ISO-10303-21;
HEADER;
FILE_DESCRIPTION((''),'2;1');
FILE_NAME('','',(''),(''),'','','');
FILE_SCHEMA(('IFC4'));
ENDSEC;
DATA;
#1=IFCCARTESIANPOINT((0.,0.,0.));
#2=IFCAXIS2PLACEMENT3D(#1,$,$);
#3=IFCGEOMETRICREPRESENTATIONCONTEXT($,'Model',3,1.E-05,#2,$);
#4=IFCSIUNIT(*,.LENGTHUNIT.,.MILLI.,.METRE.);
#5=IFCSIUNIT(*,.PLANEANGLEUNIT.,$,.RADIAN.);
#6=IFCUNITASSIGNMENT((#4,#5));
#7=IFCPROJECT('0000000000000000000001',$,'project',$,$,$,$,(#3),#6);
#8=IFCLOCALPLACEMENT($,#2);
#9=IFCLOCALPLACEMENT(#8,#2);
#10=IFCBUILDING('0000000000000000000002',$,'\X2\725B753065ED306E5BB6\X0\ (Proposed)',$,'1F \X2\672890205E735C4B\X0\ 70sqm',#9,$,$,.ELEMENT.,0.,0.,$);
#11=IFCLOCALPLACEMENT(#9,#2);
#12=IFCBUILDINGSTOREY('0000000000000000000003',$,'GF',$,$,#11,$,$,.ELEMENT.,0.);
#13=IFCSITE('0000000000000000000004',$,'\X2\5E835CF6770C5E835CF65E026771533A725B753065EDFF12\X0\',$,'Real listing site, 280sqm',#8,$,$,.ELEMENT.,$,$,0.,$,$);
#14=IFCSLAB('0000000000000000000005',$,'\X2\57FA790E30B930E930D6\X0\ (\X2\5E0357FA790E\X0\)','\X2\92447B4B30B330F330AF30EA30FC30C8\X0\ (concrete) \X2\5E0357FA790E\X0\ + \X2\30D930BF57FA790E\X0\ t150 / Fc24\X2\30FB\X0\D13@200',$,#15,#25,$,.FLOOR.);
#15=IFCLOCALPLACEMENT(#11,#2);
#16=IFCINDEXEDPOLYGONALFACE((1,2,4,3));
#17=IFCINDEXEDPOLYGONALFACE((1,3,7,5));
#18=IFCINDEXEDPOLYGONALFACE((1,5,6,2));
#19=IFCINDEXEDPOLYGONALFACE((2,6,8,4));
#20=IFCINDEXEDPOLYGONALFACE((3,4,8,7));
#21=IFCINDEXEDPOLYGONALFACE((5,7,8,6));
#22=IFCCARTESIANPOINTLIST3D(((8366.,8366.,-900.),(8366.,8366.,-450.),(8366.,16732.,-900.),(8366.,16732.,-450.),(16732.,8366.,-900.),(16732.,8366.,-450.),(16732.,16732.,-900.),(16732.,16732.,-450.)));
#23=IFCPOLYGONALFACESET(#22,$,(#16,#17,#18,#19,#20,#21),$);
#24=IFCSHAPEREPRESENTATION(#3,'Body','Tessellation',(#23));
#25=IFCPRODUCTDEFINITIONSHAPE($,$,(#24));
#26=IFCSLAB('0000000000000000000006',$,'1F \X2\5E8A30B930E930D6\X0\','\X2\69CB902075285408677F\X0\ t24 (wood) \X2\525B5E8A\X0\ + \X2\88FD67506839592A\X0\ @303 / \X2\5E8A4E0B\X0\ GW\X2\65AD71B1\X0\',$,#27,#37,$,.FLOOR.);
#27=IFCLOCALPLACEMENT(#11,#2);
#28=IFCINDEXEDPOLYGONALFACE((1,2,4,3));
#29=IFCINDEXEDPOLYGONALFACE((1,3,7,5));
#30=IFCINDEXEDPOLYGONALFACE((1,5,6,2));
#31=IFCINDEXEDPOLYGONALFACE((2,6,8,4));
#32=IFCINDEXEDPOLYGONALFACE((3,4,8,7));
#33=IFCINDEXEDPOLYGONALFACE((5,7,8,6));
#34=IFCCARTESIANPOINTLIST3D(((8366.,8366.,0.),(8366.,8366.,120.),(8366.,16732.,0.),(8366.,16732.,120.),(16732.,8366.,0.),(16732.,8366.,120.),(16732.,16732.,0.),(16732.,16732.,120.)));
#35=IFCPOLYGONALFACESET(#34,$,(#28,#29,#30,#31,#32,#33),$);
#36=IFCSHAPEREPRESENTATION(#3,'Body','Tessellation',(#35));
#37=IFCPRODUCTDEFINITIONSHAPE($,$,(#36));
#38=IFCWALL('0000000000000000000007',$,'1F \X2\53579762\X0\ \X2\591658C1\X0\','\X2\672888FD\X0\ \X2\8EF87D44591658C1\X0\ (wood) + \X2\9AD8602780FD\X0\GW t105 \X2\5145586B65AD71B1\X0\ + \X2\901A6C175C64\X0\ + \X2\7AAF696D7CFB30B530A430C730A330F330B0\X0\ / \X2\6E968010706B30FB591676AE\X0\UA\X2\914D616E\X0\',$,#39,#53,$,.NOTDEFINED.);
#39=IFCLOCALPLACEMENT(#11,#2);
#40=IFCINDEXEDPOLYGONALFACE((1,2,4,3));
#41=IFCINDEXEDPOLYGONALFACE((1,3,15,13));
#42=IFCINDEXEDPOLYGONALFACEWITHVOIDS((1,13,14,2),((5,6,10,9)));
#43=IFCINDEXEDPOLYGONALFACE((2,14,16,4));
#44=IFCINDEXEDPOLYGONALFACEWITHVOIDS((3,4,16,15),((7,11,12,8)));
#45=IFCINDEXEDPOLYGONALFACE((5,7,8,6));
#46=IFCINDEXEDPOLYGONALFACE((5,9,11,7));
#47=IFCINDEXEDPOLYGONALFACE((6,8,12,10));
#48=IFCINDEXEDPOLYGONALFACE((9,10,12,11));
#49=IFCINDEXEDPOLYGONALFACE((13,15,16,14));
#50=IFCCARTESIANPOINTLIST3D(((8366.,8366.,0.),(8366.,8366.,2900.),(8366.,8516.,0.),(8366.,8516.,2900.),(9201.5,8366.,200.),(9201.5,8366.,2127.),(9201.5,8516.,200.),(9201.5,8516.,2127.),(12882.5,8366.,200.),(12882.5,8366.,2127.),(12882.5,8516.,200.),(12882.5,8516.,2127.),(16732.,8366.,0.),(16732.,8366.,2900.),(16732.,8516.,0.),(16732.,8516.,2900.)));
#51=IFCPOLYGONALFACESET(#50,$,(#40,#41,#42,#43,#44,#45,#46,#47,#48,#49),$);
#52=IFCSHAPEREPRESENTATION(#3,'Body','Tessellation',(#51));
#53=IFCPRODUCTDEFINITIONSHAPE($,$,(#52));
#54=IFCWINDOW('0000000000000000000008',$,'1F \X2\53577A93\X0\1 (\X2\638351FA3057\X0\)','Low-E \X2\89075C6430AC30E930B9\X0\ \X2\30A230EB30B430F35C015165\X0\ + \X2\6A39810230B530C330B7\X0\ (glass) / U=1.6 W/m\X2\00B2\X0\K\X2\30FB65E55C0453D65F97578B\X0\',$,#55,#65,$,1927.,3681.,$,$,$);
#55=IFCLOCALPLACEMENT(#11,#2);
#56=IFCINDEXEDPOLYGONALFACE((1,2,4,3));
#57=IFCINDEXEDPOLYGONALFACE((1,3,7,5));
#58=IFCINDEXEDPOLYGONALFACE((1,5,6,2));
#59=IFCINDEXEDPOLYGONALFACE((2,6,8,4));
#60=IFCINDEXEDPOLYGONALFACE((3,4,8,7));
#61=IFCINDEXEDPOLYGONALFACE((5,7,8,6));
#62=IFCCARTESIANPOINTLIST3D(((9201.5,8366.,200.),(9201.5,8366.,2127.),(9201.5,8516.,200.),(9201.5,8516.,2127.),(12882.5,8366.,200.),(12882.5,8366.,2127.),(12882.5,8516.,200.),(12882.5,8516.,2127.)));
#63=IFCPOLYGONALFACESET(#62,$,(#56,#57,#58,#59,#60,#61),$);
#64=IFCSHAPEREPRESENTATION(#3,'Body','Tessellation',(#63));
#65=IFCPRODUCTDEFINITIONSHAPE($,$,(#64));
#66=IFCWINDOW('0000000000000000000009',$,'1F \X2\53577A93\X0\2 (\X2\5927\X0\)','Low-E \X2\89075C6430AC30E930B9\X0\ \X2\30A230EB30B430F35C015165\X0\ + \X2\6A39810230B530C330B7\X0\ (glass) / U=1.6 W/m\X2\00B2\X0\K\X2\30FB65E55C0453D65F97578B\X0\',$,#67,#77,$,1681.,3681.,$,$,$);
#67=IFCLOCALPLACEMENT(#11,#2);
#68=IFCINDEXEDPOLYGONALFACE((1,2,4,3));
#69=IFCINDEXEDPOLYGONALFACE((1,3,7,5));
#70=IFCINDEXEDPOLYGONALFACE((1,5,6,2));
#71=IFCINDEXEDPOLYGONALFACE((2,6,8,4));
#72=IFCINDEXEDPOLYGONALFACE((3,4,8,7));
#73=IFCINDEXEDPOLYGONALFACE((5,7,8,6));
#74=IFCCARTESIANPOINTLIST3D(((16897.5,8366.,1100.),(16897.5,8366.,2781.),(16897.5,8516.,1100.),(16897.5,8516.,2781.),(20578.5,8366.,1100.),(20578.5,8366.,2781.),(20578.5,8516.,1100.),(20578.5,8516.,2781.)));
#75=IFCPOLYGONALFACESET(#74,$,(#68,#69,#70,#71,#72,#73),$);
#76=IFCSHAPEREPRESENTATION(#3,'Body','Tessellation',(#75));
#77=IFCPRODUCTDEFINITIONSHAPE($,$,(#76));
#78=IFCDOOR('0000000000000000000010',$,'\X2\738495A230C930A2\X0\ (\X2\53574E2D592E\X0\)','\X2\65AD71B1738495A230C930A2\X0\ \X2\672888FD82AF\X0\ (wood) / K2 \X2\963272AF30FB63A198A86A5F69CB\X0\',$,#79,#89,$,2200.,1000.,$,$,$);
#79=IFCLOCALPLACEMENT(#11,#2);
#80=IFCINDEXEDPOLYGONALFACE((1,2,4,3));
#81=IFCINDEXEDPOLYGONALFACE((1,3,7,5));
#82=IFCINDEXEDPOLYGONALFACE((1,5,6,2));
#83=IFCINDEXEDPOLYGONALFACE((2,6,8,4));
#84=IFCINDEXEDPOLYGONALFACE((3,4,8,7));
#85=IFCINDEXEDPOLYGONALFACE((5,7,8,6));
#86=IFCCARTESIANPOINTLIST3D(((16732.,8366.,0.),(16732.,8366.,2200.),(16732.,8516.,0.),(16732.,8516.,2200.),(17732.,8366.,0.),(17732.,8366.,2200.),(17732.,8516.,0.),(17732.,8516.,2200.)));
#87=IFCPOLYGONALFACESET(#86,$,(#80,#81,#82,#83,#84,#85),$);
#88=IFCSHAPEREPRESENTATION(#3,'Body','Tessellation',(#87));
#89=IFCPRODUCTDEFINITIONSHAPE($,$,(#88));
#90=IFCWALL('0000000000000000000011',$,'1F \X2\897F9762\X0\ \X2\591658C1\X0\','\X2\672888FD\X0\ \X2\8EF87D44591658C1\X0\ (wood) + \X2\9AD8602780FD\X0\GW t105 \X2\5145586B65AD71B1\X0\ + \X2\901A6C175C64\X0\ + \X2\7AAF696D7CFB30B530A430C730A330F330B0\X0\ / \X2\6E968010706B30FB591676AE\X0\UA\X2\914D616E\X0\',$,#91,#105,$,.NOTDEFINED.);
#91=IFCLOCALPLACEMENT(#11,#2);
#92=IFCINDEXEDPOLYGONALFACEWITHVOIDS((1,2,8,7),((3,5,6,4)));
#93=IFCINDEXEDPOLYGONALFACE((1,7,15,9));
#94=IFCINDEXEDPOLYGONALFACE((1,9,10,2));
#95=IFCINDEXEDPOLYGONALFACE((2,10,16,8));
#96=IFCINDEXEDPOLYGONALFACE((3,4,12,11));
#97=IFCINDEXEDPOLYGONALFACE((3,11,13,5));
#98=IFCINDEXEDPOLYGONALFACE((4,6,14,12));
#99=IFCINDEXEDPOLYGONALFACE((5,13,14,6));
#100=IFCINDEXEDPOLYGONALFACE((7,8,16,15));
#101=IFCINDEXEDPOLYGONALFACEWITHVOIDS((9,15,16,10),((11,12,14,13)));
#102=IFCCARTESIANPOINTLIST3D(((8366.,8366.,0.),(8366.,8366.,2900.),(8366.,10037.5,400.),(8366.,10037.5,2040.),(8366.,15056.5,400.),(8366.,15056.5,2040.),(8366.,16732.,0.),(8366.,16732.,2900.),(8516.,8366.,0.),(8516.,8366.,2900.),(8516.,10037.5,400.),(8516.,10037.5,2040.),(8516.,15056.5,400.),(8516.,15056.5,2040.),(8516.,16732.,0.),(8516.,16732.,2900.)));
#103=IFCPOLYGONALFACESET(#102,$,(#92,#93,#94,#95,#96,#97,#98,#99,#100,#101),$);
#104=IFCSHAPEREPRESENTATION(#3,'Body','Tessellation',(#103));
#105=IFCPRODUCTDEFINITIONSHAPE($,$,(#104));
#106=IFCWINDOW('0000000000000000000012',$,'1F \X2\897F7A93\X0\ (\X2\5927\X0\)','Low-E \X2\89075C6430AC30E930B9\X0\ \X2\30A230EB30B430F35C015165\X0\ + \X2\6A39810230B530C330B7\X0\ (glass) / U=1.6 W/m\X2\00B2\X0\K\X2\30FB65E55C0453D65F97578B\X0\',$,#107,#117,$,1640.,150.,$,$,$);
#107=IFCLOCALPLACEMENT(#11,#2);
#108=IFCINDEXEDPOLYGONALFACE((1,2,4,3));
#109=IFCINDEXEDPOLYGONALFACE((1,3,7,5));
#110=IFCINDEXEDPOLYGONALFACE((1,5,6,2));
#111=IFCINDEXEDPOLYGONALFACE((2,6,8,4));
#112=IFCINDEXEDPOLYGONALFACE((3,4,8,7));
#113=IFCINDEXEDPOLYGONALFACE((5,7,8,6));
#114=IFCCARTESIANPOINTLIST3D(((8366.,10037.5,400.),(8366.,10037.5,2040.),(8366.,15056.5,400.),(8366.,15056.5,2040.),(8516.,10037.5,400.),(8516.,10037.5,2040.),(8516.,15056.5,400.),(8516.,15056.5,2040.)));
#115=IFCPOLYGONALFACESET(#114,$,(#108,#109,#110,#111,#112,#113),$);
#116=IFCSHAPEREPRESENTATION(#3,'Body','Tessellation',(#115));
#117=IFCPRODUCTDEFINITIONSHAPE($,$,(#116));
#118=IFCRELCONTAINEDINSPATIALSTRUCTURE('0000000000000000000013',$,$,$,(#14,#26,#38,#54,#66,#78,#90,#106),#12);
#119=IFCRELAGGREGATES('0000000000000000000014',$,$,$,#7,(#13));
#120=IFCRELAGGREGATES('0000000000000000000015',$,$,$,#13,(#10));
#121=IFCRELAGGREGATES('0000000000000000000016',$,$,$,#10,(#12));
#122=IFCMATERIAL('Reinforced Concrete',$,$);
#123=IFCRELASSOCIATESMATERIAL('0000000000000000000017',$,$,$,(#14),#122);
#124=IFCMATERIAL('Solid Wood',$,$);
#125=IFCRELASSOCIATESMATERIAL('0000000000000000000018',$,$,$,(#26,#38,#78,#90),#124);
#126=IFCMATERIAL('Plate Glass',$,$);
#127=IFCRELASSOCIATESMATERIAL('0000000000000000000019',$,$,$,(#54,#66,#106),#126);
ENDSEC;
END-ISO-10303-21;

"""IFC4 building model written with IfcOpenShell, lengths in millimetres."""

from ifc_helpers import new_model, si_unit, frame, frame_2d, origin, place, context, project, spatial, rectangle, extrude, material, element, fill, save


model = new_model("IFC4")

# Units and contexts
model_context = context("Model", 3, precision=1e-05, world=origin())
ifc_project = project(units=[si_unit("LENGTHUNIT", "METRE", prefix="MILLI"), si_unit("PLANEANGLEUNIT", "RADIAN")], contexts=[model_context])

# Site, building, storey
site_placement = place(None, origin())
site = spatial("IfcSite", under=ifc_project, at=site_placement, Name="広島県広島市東区牛田旭２", ObjectType="Real listing site, 280sqm", CompositionType="ELEMENT", RefElevation=0.0)
building_placement = place(site_placement, origin())
building = spatial("IfcBuilding", under=site, at=building_placement, Name="牛田旭の家 (Proposed)", ObjectType="1F 木造平屋 70sqm", CompositionType="ELEMENT", ElevationOfRefHeight=0.0, ElevationOfTerrain=0.0)
storey_placement = place(building_placement, origin())
storey = spatial("IfcBuildingStorey", under=building, at=storey_placement, Name="GF", CompositionType="ELEMENT", Elevation=0.0)

# Slabs
ifc_material_1 = material(Name="Reinforced Concrete")
slab_1_placement = place(storey_placement, frame((4183.0, 4183.0, -450.0)))
element("IfcSlab", 1, at=slab_1_placement, inside=storey, material=ifc_material_1, Name="基礎スラブ (布基礎)", Description="鉄筋コンクリート (concrete) 布基礎 + ベタ基礎 t150 / Fc24・D13@200", PredefinedType="FLOOR", context=model_context, shape_type="SweptSolid", body=[
    extrude(rectangle(XDim=8366.0, YDim=8366.0, at=frame_2d((4183.0, 4183.0))), frame((4183.0, 4183.0, -450.0)), (0.0, 0.0, 1.0), 450.0),
])
ifc_material_2 = material(Name="Solid Wood")
slab_2_placement = place(storey_placement, frame((4183.0, 4183.0, 0.0)))
element("IfcSlab", 2, at=slab_2_placement, inside=storey, material=ifc_material_2, Name="1F 床スラブ", Description="構造用合板 t24 (wood) 剛床 + 製材根太 @303 / 床下 GW断熱", PredefinedType="FLOOR", context=model_context, shape_type="SweptSolid", body=[
    extrude(rectangle(XDim=8366.0, YDim=8366.0, at=frame_2d((4183.0, 4183.0))), frame((4183.0, 4183.0, 0.0)), (0.0, 0.0, 1.0), 120.0),
])

# Wall, openings, windows, door
wall_1_placement = place(storey_placement, frame((4183.0, 4183.0, 0.0)))
wall_1 = element("IfcWall", 3, at=wall_1_placement, inside=storey, material=ifc_material_2, Name="1F 南面 外壁", Description="木製 軸組外壁 (wood) + 高性能GW t105 充填断熱 + 通気層 + 窯業系サイディング / 準耐火・外皮UA配慮", PredefinedType="NOTDEFINED", context=model_context, shape_type="SweptSolid", body=[
    extrude(rectangle(XDim=8366.0, YDim=150.0, at=frame_2d((4183.0, 75.0))), frame((4183.0, 4183.0, 0.0)), (0.0, 0.0, 1.0), 2900.0),
])
opening_1_placement = place(storey_placement, frame((4601.0, 4183.0, 100.0)))
opening_1 = element("IfcOpeningElement", 4, at=opening_1_placement, cuts=wall_1, PredefinedType="NOTDEFINED", context=model_context, shape_type="SweptSolid", body=[
    extrude(rectangle(XDim=3681.0, YDim=150.0, at=frame_2d((1840.0, 75.0))), frame((4601.0, 4183.0, 100.0)), (0.0, 0.0, 1.0), 1927.0),
])
opening_2_placement = place(storey_placement, frame((8449.0, 4183.0, 550.0)))
opening_2 = element("IfcOpeningElement", 5, at=opening_2_placement, cuts=wall_1, PredefinedType="NOTDEFINED", context=model_context, shape_type="SweptSolid", body=[
    extrude(rectangle(XDim=3681.0, YDim=150.0, at=frame_2d((1840.0, 75.0))), frame((8449.0, 4183.0, 550.0)), (0.0, 0.0, 1.0), 1681.0),
])
opening_3_placement = place(storey_placement, frame((8366.0, 4183.0, 0.0)))
opening_3 = element("IfcOpeningElement", 6, at=opening_3_placement, cuts=wall_1, PredefinedType="NOTDEFINED", context=model_context, shape_type="SweptSolid", body=[
    extrude(rectangle(XDim=1000.0, YDim=150.0, at=frame_2d((500.0, 75.0))), frame((8366.0, 4183.0, 0.0)), (0.0, 0.0, 1.0), 2200.0),
])
ifc_material_3 = material(Name="Plate Glass")
window_1_placement = place(storey_placement, frame((4601.0, 4183.0, 100.0)))
window_1 = element("IfcWindow", 7, at=window_1_placement, inside=storey, material=ifc_material_3, Name="1F 南窓1 (掃出し)", Description="Low-E 複層ガラス アルゴン封入 + 樹脂サッシ (glass) / U=1.6 W/m²K・日射取得型", OverallHeight=1927.0, OverallWidth=3681.0, context=model_context, shape_type="SweptSolid", body=[
    extrude(rectangle(XDim=3681.0, YDim=150.0, at=frame_2d((1840.0, 75.0))), frame((4601.0, 4183.0, 100.0)), (0.0, 0.0, 1.0), 1927.0),
])
fill(opening_1, window_1)
window_2_placement = place(storey_placement, frame((8449.0, 4183.0, 550.0)))
window_2 = element("IfcWindow", 8, at=window_2_placement, inside=storey, material=ifc_material_3, Name="1F 南窓2 (大)", Description="Low-E 複層ガラス アルゴン封入 + 樹脂サッシ (glass) / U=1.6 W/m²K・日射取得型", OverallHeight=1681.0, OverallWidth=3681.0, context=model_context, shape_type="SweptSolid", body=[
    extrude(rectangle(XDim=3681.0, YDim=150.0, at=frame_2d((1840.0, 75.0))), frame((8449.0, 4183.0, 550.0)), (0.0, 0.0, 1.0), 1681.0),
])
fill(opening_2, window_2)
door_placement = place(storey_placement, frame((8366.0, 4183.0, 0.0)))
door = element("IfcDoor", 9, at=door_placement, inside=storey, material=ifc_material_2, Name="玄関ドア (南中央)", Description="断熱玄関ドア 木製芯 (wood) / K2 防犯・採風機構", OverallHeight=2200.0, OverallWidth=1000.0, context=model_context, shape_type="SweptSolid", body=[
    extrude(rectangle(XDim=1000.0, YDim=150.0, at=frame_2d((500.0, 75.0))), frame((8366.0, 4183.0, 0.0)), (0.0, 0.0, 1.0), 2200.0),
])
fill(opening_3, door)

# Wall, opening, window
wall_2_placement = place(storey_placement, frame((4183.0, 4183.0, 0.0)))
wall_2 = element("IfcWall", 10, at=wall_2_placement, inside=storey, material=ifc_material_2, Name="1F 西面 外壁", Description="木製 軸組外壁 (wood) + 高性能GW t105 充填断熱 + 通気層 + 窯業系サイディング / 準耐火・外皮UA配慮", PredefinedType="NOTDEFINED", context=model_context, shape_type="SweptSolid", body=[
    extrude(rectangle(XDim=150.0, YDim=8366.0, at=frame_2d((75.0, 4183.0))), frame((4183.0, 4183.0, 0.0)), (0.0, 0.0, 1.0), 2900.0),
])
opening_4_placement = place(storey_placement, frame((4183.0, 5019.0, 200.0)))
opening_4 = element("IfcOpeningElement", 11, at=opening_4_placement, cuts=wall_2, PredefinedType="NOTDEFINED", context=model_context, shape_type="SweptSolid", body=[
    extrude(rectangle(XDim=150.0, YDim=5019.0, at=frame_2d((75.0, 2509.0))), frame((4183.0, 5019.0, 200.0)), (0.0, 0.0, 1.0), 1640.0),
])
window_3_placement = place(storey_placement, frame((4183.0, 5019.0, 200.0)))
window_3 = element("IfcWindow", 12, at=window_3_placement, inside=storey, material=ifc_material_3, Name="1F 西窓 (大)", Description="Low-E 複層ガラス アルゴン封入 + 樹脂サッシ (glass) / U=1.6 W/m²K・日射取得型", OverallHeight=1640.0, OverallWidth=150.0, context=model_context, shape_type="SweptSolid", body=[
    extrude(rectangle(XDim=150.0, YDim=5019.0, at=frame_2d((75.0, 2509.0))), frame((4183.0, 5019.0, 200.0)), (0.0, 0.0, 1.0), 1640.0),
])
fill(opening_4, window_3)

save(model, "model.ifc")
